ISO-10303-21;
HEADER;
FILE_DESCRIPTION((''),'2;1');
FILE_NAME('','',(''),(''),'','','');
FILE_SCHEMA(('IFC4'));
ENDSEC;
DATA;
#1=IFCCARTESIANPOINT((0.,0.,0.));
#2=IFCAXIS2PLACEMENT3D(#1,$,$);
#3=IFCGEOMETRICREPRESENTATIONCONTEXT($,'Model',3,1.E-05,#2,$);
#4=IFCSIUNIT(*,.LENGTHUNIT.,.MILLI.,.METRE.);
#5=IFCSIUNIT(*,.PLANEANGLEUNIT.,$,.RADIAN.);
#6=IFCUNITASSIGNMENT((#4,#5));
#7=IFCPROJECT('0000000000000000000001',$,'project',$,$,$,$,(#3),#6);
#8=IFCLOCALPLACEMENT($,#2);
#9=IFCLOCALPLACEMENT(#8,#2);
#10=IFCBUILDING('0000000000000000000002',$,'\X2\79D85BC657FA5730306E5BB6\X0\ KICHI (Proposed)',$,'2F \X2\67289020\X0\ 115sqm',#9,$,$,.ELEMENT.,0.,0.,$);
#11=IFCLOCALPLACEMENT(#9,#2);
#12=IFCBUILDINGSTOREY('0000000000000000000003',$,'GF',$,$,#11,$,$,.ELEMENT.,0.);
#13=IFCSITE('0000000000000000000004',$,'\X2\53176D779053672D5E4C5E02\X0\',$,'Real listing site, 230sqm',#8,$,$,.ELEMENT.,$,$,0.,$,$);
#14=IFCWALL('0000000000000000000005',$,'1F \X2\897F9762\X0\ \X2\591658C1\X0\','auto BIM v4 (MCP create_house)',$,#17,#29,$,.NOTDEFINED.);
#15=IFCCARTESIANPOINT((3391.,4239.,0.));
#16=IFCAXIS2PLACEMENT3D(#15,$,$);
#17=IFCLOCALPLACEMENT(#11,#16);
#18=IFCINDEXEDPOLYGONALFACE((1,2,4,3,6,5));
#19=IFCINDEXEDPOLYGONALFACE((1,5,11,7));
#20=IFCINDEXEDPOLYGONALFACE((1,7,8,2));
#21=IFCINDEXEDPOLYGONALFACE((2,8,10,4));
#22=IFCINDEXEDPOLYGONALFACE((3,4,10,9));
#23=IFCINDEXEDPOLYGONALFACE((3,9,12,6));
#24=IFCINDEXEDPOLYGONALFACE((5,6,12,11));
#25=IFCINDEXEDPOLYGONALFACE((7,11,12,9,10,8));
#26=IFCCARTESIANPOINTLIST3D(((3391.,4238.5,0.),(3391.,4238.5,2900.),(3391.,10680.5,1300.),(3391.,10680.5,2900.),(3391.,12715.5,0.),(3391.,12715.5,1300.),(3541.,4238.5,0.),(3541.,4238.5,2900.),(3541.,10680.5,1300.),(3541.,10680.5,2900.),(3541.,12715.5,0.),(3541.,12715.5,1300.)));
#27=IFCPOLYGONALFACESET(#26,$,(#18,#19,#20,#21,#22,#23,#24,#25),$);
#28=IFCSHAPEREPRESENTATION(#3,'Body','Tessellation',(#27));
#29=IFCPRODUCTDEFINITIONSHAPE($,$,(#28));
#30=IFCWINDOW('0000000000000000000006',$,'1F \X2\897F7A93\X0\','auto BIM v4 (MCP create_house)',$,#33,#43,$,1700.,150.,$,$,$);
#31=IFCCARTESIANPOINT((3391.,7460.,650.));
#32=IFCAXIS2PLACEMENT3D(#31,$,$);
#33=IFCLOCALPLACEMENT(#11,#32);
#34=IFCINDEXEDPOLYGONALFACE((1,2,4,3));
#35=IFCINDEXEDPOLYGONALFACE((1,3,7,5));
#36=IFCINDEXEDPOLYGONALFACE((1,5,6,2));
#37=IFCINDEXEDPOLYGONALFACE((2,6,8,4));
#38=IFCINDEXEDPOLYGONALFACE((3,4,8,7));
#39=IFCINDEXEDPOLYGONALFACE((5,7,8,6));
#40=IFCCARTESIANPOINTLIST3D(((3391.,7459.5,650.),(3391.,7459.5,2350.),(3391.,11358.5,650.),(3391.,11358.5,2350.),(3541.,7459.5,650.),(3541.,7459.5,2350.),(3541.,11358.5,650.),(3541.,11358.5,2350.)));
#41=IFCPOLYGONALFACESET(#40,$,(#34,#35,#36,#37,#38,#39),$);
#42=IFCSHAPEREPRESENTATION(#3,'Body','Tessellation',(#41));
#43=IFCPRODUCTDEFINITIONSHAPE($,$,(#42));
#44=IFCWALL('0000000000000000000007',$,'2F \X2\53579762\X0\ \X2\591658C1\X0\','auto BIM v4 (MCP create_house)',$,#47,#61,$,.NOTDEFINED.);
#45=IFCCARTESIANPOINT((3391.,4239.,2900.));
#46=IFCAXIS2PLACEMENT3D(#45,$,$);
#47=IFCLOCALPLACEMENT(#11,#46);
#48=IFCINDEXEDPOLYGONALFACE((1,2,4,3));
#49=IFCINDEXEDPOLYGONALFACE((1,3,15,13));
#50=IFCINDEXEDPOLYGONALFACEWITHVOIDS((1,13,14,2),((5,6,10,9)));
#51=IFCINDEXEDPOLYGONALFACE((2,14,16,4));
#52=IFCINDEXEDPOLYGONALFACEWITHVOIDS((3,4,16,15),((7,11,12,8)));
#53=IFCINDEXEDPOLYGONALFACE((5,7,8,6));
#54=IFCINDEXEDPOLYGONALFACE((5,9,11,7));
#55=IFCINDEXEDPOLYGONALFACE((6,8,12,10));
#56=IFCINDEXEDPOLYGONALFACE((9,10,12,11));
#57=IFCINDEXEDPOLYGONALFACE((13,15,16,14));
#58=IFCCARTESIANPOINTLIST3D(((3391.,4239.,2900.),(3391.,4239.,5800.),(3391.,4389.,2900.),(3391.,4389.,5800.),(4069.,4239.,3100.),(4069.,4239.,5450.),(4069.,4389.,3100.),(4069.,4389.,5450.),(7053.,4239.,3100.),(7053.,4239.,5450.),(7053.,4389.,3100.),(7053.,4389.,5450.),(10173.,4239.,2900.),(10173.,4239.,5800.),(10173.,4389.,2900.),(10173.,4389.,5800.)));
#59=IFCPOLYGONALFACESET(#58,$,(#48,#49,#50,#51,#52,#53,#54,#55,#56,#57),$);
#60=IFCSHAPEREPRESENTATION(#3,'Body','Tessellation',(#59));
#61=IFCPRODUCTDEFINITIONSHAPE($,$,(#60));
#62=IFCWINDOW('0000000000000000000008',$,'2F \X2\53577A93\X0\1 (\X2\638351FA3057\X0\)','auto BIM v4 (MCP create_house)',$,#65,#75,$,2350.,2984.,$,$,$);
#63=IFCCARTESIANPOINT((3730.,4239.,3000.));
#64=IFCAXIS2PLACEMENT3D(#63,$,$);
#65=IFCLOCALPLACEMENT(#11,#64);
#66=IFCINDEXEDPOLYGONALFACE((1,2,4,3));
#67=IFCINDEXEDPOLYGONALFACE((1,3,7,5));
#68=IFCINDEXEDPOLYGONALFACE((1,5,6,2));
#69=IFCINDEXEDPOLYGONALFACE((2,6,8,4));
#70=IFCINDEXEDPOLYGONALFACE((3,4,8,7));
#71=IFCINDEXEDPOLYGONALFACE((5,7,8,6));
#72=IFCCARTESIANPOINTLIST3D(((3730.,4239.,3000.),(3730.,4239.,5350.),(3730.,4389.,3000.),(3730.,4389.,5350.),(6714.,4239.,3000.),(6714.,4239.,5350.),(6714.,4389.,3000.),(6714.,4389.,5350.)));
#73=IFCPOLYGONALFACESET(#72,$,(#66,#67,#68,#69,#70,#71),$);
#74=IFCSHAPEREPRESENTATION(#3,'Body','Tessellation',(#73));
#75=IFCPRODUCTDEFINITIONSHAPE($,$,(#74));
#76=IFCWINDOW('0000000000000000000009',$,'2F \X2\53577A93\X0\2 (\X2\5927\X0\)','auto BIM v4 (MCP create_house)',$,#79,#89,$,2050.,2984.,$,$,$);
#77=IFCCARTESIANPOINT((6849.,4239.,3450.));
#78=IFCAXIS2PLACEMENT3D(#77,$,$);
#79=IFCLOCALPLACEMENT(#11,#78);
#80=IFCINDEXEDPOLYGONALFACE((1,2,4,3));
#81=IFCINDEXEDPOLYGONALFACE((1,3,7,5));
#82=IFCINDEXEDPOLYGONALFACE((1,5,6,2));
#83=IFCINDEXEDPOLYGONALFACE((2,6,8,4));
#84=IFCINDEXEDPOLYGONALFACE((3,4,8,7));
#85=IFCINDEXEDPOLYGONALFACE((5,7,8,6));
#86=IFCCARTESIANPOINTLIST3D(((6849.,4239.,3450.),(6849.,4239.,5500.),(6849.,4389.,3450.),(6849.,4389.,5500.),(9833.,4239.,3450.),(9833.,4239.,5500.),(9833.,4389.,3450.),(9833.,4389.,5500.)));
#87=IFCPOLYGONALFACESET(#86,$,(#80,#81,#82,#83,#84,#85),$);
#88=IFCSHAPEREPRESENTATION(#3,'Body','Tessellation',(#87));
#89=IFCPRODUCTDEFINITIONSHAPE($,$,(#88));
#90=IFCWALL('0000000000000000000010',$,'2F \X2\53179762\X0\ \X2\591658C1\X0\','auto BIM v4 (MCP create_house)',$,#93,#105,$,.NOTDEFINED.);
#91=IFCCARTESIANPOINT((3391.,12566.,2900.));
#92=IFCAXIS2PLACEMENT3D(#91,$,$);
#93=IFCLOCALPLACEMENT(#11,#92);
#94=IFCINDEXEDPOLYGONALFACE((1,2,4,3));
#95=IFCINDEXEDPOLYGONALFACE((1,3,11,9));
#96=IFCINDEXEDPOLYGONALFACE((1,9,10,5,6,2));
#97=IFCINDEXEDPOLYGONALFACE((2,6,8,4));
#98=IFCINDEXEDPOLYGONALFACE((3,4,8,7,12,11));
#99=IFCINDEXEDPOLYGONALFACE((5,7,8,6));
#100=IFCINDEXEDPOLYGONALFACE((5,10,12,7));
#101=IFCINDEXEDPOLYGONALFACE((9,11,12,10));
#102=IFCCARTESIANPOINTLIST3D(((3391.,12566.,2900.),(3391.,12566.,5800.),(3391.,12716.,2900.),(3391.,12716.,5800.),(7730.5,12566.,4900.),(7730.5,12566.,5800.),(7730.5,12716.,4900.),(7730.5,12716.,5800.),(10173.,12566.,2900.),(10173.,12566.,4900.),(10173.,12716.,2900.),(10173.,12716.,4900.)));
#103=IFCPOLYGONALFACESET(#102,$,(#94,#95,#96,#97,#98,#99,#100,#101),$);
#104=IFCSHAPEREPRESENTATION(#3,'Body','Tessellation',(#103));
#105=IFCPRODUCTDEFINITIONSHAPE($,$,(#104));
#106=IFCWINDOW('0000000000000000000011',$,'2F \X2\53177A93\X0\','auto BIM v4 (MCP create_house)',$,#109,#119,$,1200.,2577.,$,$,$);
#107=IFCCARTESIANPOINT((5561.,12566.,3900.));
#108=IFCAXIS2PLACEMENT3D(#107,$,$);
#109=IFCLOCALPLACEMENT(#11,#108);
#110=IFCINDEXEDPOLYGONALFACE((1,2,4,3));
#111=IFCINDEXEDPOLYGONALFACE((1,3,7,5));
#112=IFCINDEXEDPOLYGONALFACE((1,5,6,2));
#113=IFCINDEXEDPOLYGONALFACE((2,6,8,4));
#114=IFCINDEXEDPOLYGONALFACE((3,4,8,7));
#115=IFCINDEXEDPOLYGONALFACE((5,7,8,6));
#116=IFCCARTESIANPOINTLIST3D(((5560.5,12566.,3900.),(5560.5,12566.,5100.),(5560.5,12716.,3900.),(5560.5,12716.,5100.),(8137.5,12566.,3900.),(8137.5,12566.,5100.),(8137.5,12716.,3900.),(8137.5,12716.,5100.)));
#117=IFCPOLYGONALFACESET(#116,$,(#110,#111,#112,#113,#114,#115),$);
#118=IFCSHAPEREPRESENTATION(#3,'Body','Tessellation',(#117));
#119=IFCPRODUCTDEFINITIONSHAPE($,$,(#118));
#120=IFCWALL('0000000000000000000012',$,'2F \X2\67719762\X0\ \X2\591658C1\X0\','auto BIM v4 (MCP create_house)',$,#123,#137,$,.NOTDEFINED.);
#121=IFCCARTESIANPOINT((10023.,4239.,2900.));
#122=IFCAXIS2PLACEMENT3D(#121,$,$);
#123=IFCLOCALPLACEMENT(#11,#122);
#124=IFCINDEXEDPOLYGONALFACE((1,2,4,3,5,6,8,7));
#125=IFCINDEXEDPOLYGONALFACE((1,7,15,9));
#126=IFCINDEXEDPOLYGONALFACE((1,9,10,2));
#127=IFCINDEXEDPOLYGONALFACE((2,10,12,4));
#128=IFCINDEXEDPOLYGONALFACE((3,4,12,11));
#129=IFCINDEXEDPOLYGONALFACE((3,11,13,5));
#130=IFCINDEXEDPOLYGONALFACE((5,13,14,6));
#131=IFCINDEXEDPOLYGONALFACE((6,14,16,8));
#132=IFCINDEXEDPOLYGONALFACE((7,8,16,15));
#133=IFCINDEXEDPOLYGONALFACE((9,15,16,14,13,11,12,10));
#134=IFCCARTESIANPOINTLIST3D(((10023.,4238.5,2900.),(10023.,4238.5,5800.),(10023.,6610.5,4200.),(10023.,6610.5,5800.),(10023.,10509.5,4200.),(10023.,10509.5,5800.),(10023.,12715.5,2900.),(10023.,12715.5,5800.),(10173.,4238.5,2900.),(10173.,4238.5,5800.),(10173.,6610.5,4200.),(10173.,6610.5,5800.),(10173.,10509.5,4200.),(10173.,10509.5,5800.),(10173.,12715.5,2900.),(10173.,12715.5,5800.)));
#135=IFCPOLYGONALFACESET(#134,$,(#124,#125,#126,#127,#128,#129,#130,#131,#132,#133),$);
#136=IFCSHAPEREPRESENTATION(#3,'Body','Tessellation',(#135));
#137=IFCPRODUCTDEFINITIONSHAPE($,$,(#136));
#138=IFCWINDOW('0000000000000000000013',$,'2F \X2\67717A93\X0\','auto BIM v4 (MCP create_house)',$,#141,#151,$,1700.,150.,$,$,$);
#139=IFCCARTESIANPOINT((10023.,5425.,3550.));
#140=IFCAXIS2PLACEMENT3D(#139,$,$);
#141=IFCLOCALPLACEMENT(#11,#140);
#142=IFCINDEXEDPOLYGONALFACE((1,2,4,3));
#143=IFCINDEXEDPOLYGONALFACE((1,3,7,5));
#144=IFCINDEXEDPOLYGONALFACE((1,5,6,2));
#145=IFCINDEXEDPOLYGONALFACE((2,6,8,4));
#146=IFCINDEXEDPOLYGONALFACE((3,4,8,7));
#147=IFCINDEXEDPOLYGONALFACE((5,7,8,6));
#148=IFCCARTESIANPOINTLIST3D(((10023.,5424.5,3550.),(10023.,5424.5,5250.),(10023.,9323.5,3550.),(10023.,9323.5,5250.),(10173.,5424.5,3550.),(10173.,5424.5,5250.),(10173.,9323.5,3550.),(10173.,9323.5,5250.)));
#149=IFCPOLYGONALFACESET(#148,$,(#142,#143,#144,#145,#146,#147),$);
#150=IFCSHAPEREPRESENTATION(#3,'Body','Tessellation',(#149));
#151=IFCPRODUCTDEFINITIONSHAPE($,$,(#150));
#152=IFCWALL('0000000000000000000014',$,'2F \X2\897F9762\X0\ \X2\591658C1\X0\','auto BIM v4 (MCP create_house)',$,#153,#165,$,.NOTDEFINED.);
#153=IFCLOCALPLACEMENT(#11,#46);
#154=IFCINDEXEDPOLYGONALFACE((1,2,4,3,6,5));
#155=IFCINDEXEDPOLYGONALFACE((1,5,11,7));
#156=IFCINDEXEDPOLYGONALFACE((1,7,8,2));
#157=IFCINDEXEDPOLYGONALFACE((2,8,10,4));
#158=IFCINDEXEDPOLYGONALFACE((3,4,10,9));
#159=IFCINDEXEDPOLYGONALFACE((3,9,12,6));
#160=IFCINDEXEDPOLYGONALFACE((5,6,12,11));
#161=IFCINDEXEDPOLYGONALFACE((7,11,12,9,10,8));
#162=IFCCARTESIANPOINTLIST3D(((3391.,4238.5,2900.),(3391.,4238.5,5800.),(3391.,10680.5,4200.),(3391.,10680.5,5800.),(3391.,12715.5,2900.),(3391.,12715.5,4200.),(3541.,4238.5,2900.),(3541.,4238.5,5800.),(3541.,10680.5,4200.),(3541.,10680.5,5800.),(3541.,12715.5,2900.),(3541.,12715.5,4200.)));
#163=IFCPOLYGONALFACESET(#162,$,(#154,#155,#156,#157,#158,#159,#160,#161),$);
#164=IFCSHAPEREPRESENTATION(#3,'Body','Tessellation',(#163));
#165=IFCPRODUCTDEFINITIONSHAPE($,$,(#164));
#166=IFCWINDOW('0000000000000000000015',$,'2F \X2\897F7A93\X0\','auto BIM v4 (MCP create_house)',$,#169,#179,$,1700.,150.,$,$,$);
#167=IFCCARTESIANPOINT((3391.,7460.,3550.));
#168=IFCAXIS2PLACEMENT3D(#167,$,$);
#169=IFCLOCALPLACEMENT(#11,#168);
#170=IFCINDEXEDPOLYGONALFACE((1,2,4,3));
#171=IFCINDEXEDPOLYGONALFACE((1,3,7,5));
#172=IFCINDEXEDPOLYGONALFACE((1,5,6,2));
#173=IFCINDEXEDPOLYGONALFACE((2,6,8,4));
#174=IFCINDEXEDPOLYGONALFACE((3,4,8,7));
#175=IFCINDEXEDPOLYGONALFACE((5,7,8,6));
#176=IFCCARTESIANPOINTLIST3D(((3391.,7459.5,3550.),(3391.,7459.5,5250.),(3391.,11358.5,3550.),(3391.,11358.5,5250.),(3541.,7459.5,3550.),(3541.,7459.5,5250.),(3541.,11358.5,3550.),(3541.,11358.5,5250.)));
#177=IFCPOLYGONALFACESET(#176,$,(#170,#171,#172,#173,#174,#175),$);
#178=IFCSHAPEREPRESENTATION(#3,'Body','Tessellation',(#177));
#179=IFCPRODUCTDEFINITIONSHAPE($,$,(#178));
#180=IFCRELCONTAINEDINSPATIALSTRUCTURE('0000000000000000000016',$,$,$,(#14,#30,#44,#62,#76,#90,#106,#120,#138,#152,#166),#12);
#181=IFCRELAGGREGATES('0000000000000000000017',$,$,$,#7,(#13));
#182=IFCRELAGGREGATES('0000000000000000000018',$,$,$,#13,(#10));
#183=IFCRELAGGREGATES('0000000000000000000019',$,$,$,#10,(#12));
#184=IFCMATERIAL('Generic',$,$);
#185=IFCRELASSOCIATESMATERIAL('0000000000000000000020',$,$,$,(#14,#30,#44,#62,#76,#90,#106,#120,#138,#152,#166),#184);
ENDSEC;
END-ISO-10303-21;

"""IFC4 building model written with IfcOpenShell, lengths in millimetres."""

from ifc_helpers import new_model, si_unit, frame, frame_2d, origin, place, context, project, spatial, rectangle, extrude, material, element, fill, save


model = new_model("IFC4")

# Units and contexts
model_context = context("Model", 3, precision=1e-05, world=origin())
ifc_project = project(units=[si_unit("LENGTHUNIT", "METRE", prefix="MILLI"), si_unit("PLANEANGLEUNIT", "RADIAN")], contexts=[model_context])

# Site, building, storey
site_placement = place(None, origin())
site = spatial("IfcSite", under=ifc_project, at=site_placement, Name="北海道札幌市", ObjectType="Real listing site, 230sqm", CompositionType="ELEMENT", RefElevation=0.0)
building_placement = place(site_placement, origin())
building = spatial("IfcBuilding", under=site, at=building_placement, Name="秘密基地の家 KICHI (Proposed)", ObjectType="2F 木造 115sqm", CompositionType="ELEMENT", ElevationOfRefHeight=0.0, ElevationOfTerrain=0.0)
storey_placement = place(building_placement, origin())
storey = spatial("IfcBuildingStorey", under=building, at=storey_placement, Name="GF", CompositionType="ELEMENT", Elevation=0.0)

# Shared definitions
ifc_material = material(Name="Generic")

# Wall, opening, window
wall_1_placement = place(storey_placement, frame((3391.0, 4239.0, 0.0)))
wall_1 = element("IfcWall", 1, at=wall_1_placement, inside=storey, material=ifc_material, Name="1F 西面 外壁", Description="auto BIM v4 (MCP create_house)", PredefinedType="NOTDEFINED", context=model_context, shape_type="SweptSolid", body=[
    extrude(rectangle(XDim=150.0, YDim=8477.0, at=frame_2d((75.0, 4238.0))), frame((3391.0, 4239.0, 0.0)), (0.0, 0.0, 1.0), 2900.0),
])
opening_1_placement = place(storey_placement, frame((3391.0, 7460.0, 650.0)))
opening_1 = element("IfcOpeningElement", 2, at=opening_1_placement, cuts=wall_1, PredefinedType="NOTDEFINED", context=model_context, shape_type="SweptSolid", body=[
    extrude(rectangle(XDim=150.0, YDim=3899.0, at=frame_2d((75.0, 1949.0))), frame((3391.0, 7460.0, 650.0)), (0.0, 0.0, 1.0), 1700.0),
])
window_1_placement = place(storey_placement, frame((3391.0, 7460.0, 650.0)))
window_1 = element("IfcWindow", 3, at=window_1_placement, inside=storey, material=ifc_material, Name="1F 西窓", Description="auto BIM v4 (MCP create_house)", OverallHeight=1700.0, OverallWidth=150.0, context=model_context, shape_type="SweptSolid", body=[
    extrude(rectangle(XDim=150.0, YDim=3899.0, at=frame_2d((75.0, 1949.0))), frame((3391.0, 7460.0, 650.0)), (0.0, 0.0, 1.0), 1700.0),
])
fill(opening_1, window_1)

# Wall, openings, windows
wall_2_placement = place(storey_placement, frame((3391.0, 4239.0, 2900.0)))
wall_2 = element("IfcWall", 4, at=wall_2_placement, inside=storey, material=ifc_material, Name="2F 南面 外壁", Description="auto BIM v4 (MCP create_house)", PredefinedType="NOTDEFINED", context=model_context, shape_type="SweptSolid", body=[
    extrude(rectangle(XDim=6782.0, YDim=150.0, at=frame_2d((3391.0, 75.0))), frame((3391.0, 4239.0, 2900.0)), (0.0, 0.0, 1.0), 2900.0),
])
opening_2_placement = place(storey_placement, frame((3730.0, 4239.0, 3000.0)))
opening_2 = element("IfcOpeningElement", 5, at=opening_2_placement, cuts=wall_2, PredefinedType="NOTDEFINED", context=model_context, shape_type="SweptSolid", body=[
    extrude(rectangle(XDim=2984.0, YDim=150.0, at=frame_2d((1492.0, 75.0))), frame((3730.0, 4239.0, 3000.0)), (0.0, 0.0, 1.0), 2350.0),
])
opening_3_placement = place(storey_placement, frame((6849.0, 4239.0, 3450.0)))
opening_3 = element("IfcOpeningElement", 6, at=opening_3_placement, cuts=wall_2, PredefinedType="NOTDEFINED", context=model_context, shape_type="SweptSolid", body=[
    extrude(rectangle(XDim=2984.0, YDim=150.0, at=frame_2d((1492.0, 75.0))), frame((6849.0, 4239.0, 3450.0)), (0.0, 0.0, 1.0), 2050.0),
])
window_2_placement = place(storey_placement, frame((3730.0, 4239.0, 3000.0)))
window_2 = element("IfcWindow", 7, at=window_2_placement, inside=storey, material=ifc_material, Name="2F 南窓1 (掃出し)", Description="auto BIM v4 (MCP create_house)", OverallHeight=2350.0, OverallWidth=2984.0, context=model_context, shape_type="SweptSolid", body=[
    extrude(rectangle(XDim=2984.0, YDim=150.0, at=frame_2d((1492.0, 75.0))), frame((3730.0, 4239.0, 3000.0)), (0.0, 0.0, 1.0), 2350.0),
])
fill(opening_2, window_2)
window_3_placement = place(storey_placement, frame((6849.0, 4239.0, 3450.0)))
window_3 = element("IfcWindow", 8, at=window_3_placement, inside=storey, material=ifc_material, Name="2F 南窓2 (大)", Description="auto BIM v4 (MCP create_house)", OverallHeight=2050.0, OverallWidth=2984.0, context=model_context, shape_type="SweptSolid", body=[
    extrude(rectangle(XDim=2984.0, YDim=150.0, at=frame_2d((1492.0, 75.0))), frame((6849.0, 4239.0, 3450.0)), (0.0, 0.0, 1.0), 2050.0),
])
fill(opening_3, window_3)

# Walls, openings, windows
wall_3_placement = place(storey_placement, frame((3391.0, 12566.0, 2900.0)))
wall_3 = element("IfcWall", 9, at=wall_3_placement, inside=storey, material=ifc_material, Name="2F 北面 外壁", Description="auto BIM v4 (MCP create_house)", PredefinedType="NOTDEFINED", context=model_context, shape_type="SweptSolid", body=[
    extrude(rectangle(XDim=6782.0, YDim=150.0, at=frame_2d((3391.0, 75.0))), frame((3391.0, 12566.0, 2900.0)), (0.0, 0.0, 1.0), 2900.0),
])
opening_4_placement = place(storey_placement, frame((5561.0, 12566.0, 3900.0)))
opening_4 = element("IfcOpeningElement", 10, at=opening_4_placement, cuts=wall_3, PredefinedType="NOTDEFINED", context=model_context, shape_type="SweptSolid", body=[
    extrude(rectangle(XDim=2577.0, YDim=150.0, at=frame_2d((1288.0, 75.0))), frame((5561.0, 12566.0, 3900.0)), (0.0, 0.0, 1.0), 1200.0),
])
window_4_placement = place(storey_placement, frame((5561.0, 12566.0, 3900.0)))
window_4 = element("IfcWindow", 11, at=window_4_placement, inside=storey, material=ifc_material, Name="2F 北窓", Description="auto BIM v4 (MCP create_house)", OverallHeight=1200.0, OverallWidth=2577.0, context=model_context, shape_type="SweptSolid", body=[
    extrude(rectangle(XDim=2577.0, YDim=150.0, at=frame_2d((1288.0, 75.0))), frame((5561.0, 12566.0, 3900.0)), (0.0, 0.0, 1.0), 1200.0),
])
fill(opening_4, window_4)
wall_4_placement = place(storey_placement, frame((10023.0, 4239.0, 2900.0)))
wall_4 = element("IfcWall", 12, at=wall_4_placement, inside=storey, material=ifc_material, Name="2F 東面 外壁", Description="auto BIM v4 (MCP create_house)", PredefinedType="NOTDEFINED", context=model_context, shape_type="SweptSolid", body=[
    extrude(rectangle(XDim=150.0, YDim=8477.0, at=frame_2d((75.0, 4238.0))), frame((10023.0, 4239.0, 2900.0)), (0.0, 0.0, 1.0), 2900.0),
])
opening_5_placement = place(storey_placement, frame((10023.0, 5425.0, 3550.0)))
opening_5 = element("IfcOpeningElement", 13, at=opening_5_placement, cuts=wall_4, PredefinedType="NOTDEFINED", context=model_context, shape_type="SweptSolid", body=[
    extrude(rectangle(XDim=150.0, YDim=3899.0, at=frame_2d((75.0, 1949.0))), frame((10023.0, 5425.0, 3550.0)), (0.0, 0.0, 1.0), 1700.0),
])
window_5_placement = place(storey_placement, frame((10023.0, 5425.0, 3550.0)))
window_5 = element("IfcWindow", 14, at=window_5_placement, inside=storey, material=ifc_material, Name="2F 東窓", Description="auto BIM v4 (MCP create_house)", OverallHeight=1700.0, OverallWidth=150.0, context=model_context, shape_type="SweptSolid", body=[
    extrude(rectangle(XDim=150.0, YDim=3899.0, at=frame_2d((75.0, 1949.0))), frame((10023.0, 5425.0, 3550.0)), (0.0, 0.0, 1.0), 1700.0),
])
fill(opening_5, window_5)
wall_5_placement = place(storey_placement, frame((3391.0, 4239.0, 2900.0)))
wall_5 = element("IfcWall", 15, at=wall_5_placement, inside=storey, material=ifc_material, Name="2F 西面 外壁", Description="auto BIM v4 (MCP create_house)", PredefinedType="NOTDEFINED", context=model_context, shape_type="SweptSolid", body=[
    extrude(rectangle(XDim=150.0, YDim=8477.0, at=frame_2d((75.0, 4238.0))), frame((3391.0, 4239.0, 2900.0)), (0.0, 0.0, 1.0), 2900.0),
])
opening_6_placement = place(storey_placement, frame((3391.0, 7460.0, 3550.0)))
opening_6 = element("IfcOpeningElement", 16, at=opening_6_placement, cuts=wall_5, PredefinedType="NOTDEFINED", context=model_context, shape_type="SweptSolid", body=[
    extrude(rectangle(XDim=150.0, YDim=3899.0, at=frame_2d((75.0, 1949.0))), frame((3391.0, 7460.0, 3550.0)), (0.0, 0.0, 1.0), 1700.0),
])
window_6_placement = place(storey_placement, frame((3391.0, 7460.0, 3550.0)))
window_6 = element("IfcWindow", 17, at=window_6_placement, inside=storey, material=ifc_material, Name="2F 西窓", Description="auto BIM v4 (MCP create_house)", OverallHeight=1700.0, OverallWidth=150.0, context=model_context, shape_type="SweptSolid", body=[
    extrude(rectangle(XDim=150.0, YDim=3899.0, at=frame_2d((75.0, 1949.0))), frame((3391.0, 7460.0, 3550.0)), (0.0, 0.0, 1.0), 1700.0),
])
fill(opening_6, window_6)

save(model, "model.ifc")
